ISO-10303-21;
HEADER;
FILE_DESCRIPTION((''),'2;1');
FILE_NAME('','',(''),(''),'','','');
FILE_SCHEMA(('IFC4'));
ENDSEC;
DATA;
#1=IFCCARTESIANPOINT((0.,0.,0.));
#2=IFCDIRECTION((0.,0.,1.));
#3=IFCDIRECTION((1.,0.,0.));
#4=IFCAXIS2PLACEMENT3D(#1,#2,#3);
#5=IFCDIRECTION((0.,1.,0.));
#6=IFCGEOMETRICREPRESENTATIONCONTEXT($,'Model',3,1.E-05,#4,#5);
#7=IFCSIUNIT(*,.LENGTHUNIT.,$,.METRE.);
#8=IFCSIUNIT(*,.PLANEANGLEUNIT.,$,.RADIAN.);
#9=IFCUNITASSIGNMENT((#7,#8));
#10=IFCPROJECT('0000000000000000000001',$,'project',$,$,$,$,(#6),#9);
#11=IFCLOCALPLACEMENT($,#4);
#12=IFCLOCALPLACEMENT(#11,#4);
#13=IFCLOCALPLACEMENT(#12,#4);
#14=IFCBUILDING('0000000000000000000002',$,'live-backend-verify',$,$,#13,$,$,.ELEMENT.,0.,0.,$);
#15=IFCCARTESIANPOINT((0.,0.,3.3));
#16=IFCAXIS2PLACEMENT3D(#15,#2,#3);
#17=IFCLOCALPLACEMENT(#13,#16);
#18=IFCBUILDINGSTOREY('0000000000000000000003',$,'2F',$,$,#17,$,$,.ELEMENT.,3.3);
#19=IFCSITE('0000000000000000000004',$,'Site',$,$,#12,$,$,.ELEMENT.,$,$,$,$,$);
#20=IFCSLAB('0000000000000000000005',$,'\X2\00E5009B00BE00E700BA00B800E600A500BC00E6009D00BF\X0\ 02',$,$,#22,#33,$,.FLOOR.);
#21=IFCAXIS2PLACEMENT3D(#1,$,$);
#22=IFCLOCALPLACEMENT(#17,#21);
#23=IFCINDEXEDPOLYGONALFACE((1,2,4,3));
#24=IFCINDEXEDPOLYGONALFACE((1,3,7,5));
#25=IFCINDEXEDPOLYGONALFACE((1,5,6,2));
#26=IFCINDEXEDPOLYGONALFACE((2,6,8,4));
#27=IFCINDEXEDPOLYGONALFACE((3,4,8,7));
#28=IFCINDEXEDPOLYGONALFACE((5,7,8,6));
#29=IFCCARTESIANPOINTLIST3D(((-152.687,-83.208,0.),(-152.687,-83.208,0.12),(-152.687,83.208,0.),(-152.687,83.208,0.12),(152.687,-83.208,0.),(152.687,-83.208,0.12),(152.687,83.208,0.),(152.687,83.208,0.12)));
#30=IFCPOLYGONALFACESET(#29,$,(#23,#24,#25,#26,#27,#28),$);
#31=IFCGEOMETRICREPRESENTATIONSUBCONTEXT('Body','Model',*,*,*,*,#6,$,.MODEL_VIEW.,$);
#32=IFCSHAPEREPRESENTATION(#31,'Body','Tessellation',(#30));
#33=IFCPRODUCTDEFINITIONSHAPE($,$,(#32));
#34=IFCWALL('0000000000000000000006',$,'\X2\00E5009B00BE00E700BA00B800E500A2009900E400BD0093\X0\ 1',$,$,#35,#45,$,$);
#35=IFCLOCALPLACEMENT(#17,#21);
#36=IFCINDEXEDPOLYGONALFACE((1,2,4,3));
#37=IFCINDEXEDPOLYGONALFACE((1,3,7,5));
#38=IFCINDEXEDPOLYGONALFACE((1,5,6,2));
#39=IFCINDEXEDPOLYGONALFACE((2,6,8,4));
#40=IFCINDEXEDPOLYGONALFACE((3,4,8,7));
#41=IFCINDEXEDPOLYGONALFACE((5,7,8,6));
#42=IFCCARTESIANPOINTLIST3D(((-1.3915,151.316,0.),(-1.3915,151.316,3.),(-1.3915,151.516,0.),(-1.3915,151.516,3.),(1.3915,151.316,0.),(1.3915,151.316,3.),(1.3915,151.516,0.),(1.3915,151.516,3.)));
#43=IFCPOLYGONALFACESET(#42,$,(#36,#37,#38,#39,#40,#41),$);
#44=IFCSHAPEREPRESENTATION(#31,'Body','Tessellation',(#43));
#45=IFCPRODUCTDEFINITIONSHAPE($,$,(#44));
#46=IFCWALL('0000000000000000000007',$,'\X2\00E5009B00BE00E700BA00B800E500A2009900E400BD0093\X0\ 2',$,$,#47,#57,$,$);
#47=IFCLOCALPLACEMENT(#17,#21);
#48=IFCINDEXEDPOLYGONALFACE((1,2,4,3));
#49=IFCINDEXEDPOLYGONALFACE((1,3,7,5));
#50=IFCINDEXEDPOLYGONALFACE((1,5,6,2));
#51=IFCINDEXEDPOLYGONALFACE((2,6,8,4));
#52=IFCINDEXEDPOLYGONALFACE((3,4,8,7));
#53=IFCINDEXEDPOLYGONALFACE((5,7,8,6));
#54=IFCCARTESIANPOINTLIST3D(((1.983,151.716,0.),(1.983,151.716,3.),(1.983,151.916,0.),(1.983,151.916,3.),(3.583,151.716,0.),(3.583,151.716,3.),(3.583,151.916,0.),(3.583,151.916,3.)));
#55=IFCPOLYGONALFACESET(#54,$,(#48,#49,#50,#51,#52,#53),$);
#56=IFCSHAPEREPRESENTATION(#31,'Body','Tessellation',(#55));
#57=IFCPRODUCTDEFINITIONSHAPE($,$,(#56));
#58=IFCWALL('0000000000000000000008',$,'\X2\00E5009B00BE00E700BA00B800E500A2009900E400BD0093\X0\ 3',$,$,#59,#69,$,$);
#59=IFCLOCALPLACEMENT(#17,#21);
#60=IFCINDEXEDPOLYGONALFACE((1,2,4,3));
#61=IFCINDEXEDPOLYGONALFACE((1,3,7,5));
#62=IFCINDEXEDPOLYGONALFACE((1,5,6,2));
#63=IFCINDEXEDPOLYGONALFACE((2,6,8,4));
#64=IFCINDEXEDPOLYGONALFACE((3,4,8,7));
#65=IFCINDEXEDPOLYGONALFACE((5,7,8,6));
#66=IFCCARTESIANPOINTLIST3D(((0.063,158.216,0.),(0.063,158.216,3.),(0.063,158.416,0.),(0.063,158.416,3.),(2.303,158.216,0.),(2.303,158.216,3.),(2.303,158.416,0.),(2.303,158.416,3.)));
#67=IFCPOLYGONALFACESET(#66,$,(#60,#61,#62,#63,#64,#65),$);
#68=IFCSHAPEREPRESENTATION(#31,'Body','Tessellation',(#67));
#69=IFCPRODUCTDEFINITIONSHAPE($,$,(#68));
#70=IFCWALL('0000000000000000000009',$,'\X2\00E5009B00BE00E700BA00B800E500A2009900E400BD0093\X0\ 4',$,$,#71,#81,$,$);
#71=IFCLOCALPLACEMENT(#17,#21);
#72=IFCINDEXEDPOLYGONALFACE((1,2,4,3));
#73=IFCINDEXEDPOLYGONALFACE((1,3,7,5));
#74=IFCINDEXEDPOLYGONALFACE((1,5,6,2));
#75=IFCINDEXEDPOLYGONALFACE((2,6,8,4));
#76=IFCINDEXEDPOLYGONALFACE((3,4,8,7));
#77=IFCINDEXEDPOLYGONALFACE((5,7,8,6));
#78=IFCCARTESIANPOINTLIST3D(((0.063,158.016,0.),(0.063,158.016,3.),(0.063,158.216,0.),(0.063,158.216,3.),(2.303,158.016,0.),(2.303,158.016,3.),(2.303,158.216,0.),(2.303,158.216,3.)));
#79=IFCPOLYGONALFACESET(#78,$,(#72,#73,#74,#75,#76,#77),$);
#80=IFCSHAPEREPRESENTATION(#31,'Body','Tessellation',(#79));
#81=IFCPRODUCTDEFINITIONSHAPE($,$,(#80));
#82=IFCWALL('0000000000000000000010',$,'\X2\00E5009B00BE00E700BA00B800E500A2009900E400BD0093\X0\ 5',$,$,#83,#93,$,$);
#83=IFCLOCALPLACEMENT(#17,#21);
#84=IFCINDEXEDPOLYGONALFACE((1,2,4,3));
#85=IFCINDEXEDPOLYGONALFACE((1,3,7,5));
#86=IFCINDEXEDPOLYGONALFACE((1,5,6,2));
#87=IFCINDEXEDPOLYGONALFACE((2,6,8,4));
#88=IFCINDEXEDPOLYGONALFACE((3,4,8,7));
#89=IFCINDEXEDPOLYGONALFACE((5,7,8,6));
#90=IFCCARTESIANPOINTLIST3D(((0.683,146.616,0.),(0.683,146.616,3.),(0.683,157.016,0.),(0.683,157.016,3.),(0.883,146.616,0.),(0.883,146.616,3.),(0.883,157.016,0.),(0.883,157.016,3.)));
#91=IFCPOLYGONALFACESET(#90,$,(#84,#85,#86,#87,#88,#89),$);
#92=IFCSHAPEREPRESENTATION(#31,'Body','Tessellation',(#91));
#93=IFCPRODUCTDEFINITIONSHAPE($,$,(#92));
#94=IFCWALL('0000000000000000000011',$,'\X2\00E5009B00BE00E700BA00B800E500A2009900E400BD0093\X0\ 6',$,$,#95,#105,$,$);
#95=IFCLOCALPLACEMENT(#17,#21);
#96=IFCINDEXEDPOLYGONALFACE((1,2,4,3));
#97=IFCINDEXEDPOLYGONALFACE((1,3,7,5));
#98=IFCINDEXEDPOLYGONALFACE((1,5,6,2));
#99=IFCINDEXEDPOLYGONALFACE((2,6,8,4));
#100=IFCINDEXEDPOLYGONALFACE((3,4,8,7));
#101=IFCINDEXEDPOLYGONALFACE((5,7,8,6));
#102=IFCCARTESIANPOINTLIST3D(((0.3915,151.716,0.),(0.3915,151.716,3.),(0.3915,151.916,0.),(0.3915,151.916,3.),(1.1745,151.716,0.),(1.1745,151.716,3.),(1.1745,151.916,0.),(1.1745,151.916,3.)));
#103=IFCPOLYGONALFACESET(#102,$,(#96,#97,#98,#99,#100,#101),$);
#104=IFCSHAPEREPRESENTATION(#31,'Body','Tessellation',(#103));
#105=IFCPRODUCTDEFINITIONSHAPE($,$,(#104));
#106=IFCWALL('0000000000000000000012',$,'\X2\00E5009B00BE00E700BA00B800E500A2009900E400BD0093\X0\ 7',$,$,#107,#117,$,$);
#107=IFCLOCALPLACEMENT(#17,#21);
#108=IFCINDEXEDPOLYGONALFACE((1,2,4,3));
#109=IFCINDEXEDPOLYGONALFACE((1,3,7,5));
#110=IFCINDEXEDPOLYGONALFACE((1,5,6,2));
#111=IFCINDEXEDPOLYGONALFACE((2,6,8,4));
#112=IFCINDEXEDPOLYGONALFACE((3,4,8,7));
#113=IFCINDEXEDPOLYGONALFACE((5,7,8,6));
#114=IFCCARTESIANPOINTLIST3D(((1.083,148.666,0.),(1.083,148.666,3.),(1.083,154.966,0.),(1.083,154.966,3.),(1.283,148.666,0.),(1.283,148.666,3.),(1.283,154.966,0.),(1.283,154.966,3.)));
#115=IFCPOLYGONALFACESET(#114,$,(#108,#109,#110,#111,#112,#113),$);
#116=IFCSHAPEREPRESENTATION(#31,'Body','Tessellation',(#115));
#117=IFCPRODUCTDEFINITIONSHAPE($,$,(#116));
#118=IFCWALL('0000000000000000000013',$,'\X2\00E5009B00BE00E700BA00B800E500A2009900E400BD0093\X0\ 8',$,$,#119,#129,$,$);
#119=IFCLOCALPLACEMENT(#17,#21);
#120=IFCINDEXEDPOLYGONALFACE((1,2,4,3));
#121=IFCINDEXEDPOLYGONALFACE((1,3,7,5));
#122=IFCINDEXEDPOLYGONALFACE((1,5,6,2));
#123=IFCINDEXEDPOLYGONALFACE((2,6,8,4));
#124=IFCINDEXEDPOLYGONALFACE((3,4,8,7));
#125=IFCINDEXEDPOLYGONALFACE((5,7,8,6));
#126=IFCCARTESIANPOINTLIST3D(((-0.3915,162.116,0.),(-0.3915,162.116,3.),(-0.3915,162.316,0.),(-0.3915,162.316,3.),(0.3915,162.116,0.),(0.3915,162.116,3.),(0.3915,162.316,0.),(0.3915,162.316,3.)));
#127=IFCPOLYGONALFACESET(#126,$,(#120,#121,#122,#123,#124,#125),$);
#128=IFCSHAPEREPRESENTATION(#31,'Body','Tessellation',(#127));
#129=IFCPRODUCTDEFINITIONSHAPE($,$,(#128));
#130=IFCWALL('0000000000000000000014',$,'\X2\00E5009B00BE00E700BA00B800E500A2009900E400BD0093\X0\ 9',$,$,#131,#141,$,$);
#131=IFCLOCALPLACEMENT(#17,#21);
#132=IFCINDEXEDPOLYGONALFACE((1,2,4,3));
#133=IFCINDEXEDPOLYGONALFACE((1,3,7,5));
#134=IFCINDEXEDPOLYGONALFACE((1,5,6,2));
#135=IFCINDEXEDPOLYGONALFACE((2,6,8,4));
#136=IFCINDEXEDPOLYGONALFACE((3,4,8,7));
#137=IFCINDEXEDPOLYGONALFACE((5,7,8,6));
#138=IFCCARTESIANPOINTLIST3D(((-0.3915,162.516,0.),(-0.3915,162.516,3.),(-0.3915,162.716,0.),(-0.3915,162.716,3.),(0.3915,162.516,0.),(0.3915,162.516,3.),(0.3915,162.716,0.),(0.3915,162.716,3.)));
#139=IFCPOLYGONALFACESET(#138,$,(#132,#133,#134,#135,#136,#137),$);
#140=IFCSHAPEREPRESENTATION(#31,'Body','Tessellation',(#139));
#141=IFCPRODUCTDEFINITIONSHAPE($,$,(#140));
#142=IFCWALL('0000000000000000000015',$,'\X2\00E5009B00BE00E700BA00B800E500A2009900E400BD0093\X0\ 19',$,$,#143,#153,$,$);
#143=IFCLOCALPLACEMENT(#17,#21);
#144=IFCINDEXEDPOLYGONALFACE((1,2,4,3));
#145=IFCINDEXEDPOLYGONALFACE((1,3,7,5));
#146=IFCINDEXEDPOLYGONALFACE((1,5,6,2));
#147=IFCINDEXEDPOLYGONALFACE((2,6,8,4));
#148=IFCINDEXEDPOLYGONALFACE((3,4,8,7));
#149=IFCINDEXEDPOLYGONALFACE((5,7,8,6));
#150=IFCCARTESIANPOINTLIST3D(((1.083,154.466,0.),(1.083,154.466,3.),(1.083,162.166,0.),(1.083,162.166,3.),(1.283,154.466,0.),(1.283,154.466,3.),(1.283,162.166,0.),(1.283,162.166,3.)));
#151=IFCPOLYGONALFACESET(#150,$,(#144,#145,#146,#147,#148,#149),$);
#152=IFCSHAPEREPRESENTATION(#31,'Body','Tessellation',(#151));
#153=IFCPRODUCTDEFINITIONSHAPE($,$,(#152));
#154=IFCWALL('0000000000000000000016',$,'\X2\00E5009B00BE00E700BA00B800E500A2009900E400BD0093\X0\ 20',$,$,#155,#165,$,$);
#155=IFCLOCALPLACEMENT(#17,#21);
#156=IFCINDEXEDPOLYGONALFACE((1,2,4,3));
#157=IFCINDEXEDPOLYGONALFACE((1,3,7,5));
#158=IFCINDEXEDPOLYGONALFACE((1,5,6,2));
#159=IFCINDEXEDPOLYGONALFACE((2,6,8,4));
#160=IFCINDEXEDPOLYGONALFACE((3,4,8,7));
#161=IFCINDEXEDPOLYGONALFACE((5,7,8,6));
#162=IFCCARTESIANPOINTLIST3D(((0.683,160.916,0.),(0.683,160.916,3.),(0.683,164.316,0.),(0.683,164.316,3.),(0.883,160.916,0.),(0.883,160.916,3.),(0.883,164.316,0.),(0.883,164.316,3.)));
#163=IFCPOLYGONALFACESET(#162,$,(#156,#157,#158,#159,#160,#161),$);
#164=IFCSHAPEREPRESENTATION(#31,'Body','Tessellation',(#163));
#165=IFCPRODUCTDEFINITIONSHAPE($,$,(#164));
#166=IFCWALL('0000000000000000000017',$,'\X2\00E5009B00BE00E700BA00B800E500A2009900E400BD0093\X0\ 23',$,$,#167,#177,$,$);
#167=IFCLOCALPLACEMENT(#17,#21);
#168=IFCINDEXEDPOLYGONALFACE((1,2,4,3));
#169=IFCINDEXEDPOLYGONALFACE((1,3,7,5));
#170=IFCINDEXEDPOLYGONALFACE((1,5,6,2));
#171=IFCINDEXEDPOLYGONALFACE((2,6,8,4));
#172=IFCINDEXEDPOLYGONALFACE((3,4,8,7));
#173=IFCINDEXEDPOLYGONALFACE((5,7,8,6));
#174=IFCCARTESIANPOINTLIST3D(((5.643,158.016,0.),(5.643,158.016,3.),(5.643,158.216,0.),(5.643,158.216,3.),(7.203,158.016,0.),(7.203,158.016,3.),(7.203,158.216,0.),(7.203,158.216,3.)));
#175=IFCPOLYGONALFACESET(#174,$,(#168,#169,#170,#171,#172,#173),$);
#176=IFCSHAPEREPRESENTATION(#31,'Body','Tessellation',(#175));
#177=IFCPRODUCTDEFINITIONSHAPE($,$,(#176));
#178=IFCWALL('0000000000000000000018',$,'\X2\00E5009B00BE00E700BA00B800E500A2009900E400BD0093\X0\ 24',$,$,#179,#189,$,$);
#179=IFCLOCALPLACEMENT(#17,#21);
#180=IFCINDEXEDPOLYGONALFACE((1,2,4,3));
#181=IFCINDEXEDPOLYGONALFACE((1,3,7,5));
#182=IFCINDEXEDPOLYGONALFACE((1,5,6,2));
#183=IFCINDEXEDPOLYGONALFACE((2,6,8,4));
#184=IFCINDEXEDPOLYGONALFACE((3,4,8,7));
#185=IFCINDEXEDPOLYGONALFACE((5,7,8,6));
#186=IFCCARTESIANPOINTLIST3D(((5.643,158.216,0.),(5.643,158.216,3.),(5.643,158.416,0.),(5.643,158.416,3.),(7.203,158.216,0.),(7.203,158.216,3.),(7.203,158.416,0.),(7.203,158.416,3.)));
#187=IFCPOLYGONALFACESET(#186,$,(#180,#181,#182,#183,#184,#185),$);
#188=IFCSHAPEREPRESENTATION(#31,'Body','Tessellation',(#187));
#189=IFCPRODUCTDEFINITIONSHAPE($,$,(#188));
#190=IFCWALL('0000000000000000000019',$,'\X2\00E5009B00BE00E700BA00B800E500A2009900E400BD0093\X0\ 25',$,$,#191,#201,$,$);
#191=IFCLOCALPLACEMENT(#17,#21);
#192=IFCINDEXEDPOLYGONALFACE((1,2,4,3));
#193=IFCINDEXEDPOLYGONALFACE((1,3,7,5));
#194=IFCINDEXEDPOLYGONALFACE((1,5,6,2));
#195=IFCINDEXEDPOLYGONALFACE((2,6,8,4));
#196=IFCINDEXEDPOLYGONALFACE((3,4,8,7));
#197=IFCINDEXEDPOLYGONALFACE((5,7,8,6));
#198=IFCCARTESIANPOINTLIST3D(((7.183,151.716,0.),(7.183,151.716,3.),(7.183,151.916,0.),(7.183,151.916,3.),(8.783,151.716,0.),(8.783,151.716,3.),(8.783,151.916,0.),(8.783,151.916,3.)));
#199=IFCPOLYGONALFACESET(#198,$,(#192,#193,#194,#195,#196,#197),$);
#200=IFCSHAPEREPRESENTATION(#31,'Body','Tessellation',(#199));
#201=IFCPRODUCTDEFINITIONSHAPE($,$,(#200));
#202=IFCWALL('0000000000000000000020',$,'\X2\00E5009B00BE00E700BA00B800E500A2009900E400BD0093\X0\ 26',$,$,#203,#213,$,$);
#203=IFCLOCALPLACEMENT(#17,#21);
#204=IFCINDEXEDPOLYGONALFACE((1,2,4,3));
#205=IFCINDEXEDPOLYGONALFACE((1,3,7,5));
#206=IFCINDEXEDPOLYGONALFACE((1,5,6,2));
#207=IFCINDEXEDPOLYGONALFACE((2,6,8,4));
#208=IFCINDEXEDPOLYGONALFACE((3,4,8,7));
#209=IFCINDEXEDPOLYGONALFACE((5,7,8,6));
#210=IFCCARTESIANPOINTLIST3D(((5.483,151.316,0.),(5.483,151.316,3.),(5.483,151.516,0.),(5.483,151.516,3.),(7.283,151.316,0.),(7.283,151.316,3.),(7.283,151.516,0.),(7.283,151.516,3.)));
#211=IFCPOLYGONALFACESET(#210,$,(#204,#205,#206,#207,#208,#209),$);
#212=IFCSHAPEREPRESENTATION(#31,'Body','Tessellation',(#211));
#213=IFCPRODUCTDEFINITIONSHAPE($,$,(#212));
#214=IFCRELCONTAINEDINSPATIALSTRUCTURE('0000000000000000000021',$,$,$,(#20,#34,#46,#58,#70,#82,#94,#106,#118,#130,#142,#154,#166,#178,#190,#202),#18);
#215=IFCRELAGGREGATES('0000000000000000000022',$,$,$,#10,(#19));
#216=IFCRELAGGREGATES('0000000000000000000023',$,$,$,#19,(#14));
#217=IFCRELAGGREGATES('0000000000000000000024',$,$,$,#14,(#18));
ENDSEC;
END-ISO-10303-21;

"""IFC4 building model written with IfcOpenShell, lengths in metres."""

from ifc_helpers import new_model, si_unit, direction, frame, frame_2d, origin_with_axes, place, context, subcontext, project, spatial, rectangle, extrude, element, save


model = new_model("IFC4")

# Units and contexts
model_context = context("Model", 3, precision=1e-05, world=origin_with_axes(), true_north=direction((0.0, 1.0, 0.0)))
body_context = subcontext(model_context, "Body", "Model", "MODEL_VIEW")
ifc_project = project(units=[si_unit("LENGTHUNIT", "METRE"), si_unit("PLANEANGLEUNIT", "RADIAN")], contexts=[model_context])

# Site, building, storey
placement = place(None, origin_with_axes())
site_placement = place(placement, origin_with_axes())
site = spatial("IfcSite", under=ifc_project, at=site_placement, Name="Site", CompositionType="ELEMENT")
building_placement = place(site_placement, origin_with_axes())
building = spatial("IfcBuilding", under=site, at=building_placement, Name="live-backend-verify", CompositionType="ELEMENT", ElevationOfRefHeight=0.0, ElevationOfTerrain=0.0)
storey_placement = place(building_placement, frame((0.0, 0.0, 3.3), z_axis=(0.0, 0.0, 1.0), x_axis=(1.0, 0.0, 0.0)))
storey = spatial("IfcBuildingStorey", under=building, at=storey_placement, Name="2F", CompositionType="ELEMENT", Elevation=3.3)

# Slab
slab_placement = place(storey_placement, origin_with_axes())
element("IfcSlab", 1, at=slab_placement, inside=storey, Name="å\u009b¾çº¸æ¥¼æ\u009d¿ 02", PredefinedType="FLOOR", context=body_context, shape_type="SweptSolid", body=[
    extrude(rectangle(XDim=305.374, YDim=166.416, at=frame_2d((0.0, 0.0), x_axis=(1.0, 0.0, 0.0))), frame((0.0, 0.0, 0.0), z_axis=(0.0, 0.0, 1.0)), (0.0, 0.0, 1.0), 0.12),
])

# Walls
wall_1_placement = place(storey_placement, frame((0.0, 151.416, 0.0), z_axis=(0.0, 0.0, 1.0), x_axis=(1.0, 0.0, 0.0)))
element("IfcWall", 2, at=wall_1_placement, inside=storey, Name="å\u009b¾çº¸å¢\u0099ä½\u0093 1", context=body_context, shape_type="SweptSolid", body=[
    extrude(rectangle(XDim=2.783, YDim=0.2, at=frame_2d((0.0, 0.0), x_axis=(1.0, 0.0, 0.0))), frame((0.0, 0.0, 0.0), z_axis=(0.0, 0.0, 1.0)), (0.0, 0.0, 1.0), 3.0),
])
wall_2_placement = place(storey_placement, frame((2.783, 151.816, 0.0), z_axis=(0.0, 0.0, 1.0), x_axis=(-1.0, 0.0, 0.0)))
element("IfcWall", 3, at=wall_2_placement, inside=storey, Name="å\u009b¾çº¸å¢\u0099ä½\u0093 2", context=body_context, shape_type="SweptSolid", body=[
    extrude(rectangle(XDim=1.6, YDim=0.2, at=frame_2d((0.0, 0.0), x_axis=(1.0, 0.0, 0.0))), frame((0.0, 0.0, 0.0), z_axis=(0.0, 0.0, 1.0)), (0.0, 0.0, 1.0), 3.0),
])
for number, where, z_axis, x_axis, name in (
    (4, (1.183, 158.316, 0.0), (0.0, 0.0, 1.0), (1.0, 0.0, 0.0), "å\u009b¾çº¸å¢\u0099ä½\u0093 3"),
    (5, (1.183, 158.116, 0.0), (0.0, 0.0, 1.0), (1.0, 0.0, 0.0), "å\u009b¾çº¸å¢\u0099ä½\u0093 4"),
):
    element("IfcWall", number, at=place(storey_placement, frame(where, z_axis=z_axis, x_axis=x_axis)), inside=storey, Name=name, context=body_context, shape_type="SweptSolid", body=[
        extrude(rectangle(XDim=2.24, YDim=0.2, at=frame_2d((0.0, 0.0), x_axis=(1.0, 0.0, 0.0))), frame((0.0, 0.0, 0.0), z_axis=(0.0, 0.0, 1.0)), (0.0, 0.0, 1.0), 3.0),
    ])
wall_3_placement = place(storey_placement, frame((0.783, 151.816, 0.0), z_axis=(0.0, 0.0, 1.0), x_axis=(0.0, 1.0, 0.0)))
element("IfcWall", 6, at=wall_3_placement, inside=storey, Name="å\u009b¾çº¸å¢\u0099ä½\u0093 5", context=body_context, shape_type="SweptSolid", body=[
    extrude(rectangle(XDim=10.4, YDim=0.2, at=frame_2d((0.0, 0.0), x_axis=(1.0, 0.0, 0.0))), frame((0.0, 0.0, 0.0), z_axis=(0.0, 0.0, 1.0)), (0.0, 0.0, 1.0), 3.0),
])
wall_4_placement = place(storey_placement, frame((0.783, 151.816, 0.0), z_axis=(0.0, 0.0, 1.0), x_axis=(-1.0, 0.0, 0.0)))
element("IfcWall", 7, at=wall_4_placement, inside=storey, Name="å\u009b¾çº¸å¢\u0099ä½\u0093 6", context=body_context, shape_type="SweptSolid", body=[
    extrude(rectangle(XDim=0.783, YDim=0.2, at=frame_2d((0.0, 0.0), x_axis=(1.0, 0.0, 0.0))), frame((0.0, 0.0, 0.0), z_axis=(0.0, 0.0, 1.0)), (0.0, 0.0, 1.0), 3.0),
])
wall_5_placement = place(storey_placement, frame((1.183, 151.816, 0.0), z_axis=(0.0, 0.0, 1.0), x_axis=(0.0, 1.0, 0.0)))
element("IfcWall", 8, at=wall_5_placement, inside=storey, Name="å\u009b¾çº¸å¢\u0099ä½\u0093 7", context=body_context, shape_type="SweptSolid", body=[
    extrude(rectangle(XDim=6.3, YDim=0.2, at=frame_2d((0.0, 0.0), x_axis=(1.0, 0.0, 0.0))), frame((0.0, 0.0, 0.0), z_axis=(0.0, 0.0, 1.0)), (0.0, 0.0, 1.0), 3.0),
])
for number, where, z_axis, x_axis, name in (
    (9, (0.0, 162.216, 0.0), (0.0, 0.0, 1.0), (1.0, 0.0, 0.0), "å\u009b¾çº¸å¢\u0099ä½\u0093 8"),
    (10, (0.0, 162.616, 0.0), (0.0, 0.0, 1.0), (1.0, 0.0, 0.0), "å\u009b¾çº¸å¢\u0099ä½\u0093 9"),
):
    element("IfcWall", number, at=place(storey_placement, frame(where, z_axis=z_axis, x_axis=x_axis)), inside=storey, Name=name, context=body_context, shape_type="SweptSolid", body=[
        extrude(rectangle(XDim=0.783, YDim=0.2, at=frame_2d((0.0, 0.0), x_axis=(1.0, 0.0, 0.0))), frame((0.0, 0.0, 0.0), z_axis=(0.0, 0.0, 1.0)), (0.0, 0.0, 1.0), 3.0),
    ])
wall_6_placement = place(storey_placement, frame((1.183, 158.316, 0.0), z_axis=(0.0, 0.0, 1.0), x_axis=(0.0, 1.0, 0.0)))
element("IfcWall", 11, at=wall_6_placement, inside=storey, Name="å\u009b¾çº¸å¢\u0099ä½\u0093 19", context=body_context, shape_type="SweptSolid", body=[
    extrude(rectangle(XDim=7.7, YDim=0.2, at=frame_2d((0.0, 0.0), x_axis=(1.0, 0.0, 0.0))), frame((0.0, 0.0, 0.0), z_axis=(0.0, 0.0, 1.0)), (0.0, 0.0, 1.0), 3.0),
])
wall_7_placement = place(storey_placement, frame((0.783, 162.616, 0.0), z_axis=(0.0, 0.0, 1.0), x_axis=(0.0, 1.0, 0.0)))
element("IfcWall", 12, at=wall_7_placement, inside=storey, Name="å\u009b¾çº¸å¢\u0099ä½\u0093 20", context=body_context, shape_type="SweptSolid", body=[
    extrude(rectangle(XDim=3.4, YDim=0.2, at=frame_2d((0.0, 0.0), x_axis=(1.0, 0.0, 0.0))), frame((0.0, 0.0, 0.0), z_axis=(0.0, 0.0, 1.0)), (0.0, 0.0, 1.0), 3.0),
])
for number, where, z_axis, x_axis, name in (
    (13, (6.423, 158.116, 0.0), (0.0, 0.0, 1.0), (1.0, 0.0, 0.0), "å\u009b¾çº¸å¢\u0099ä½\u0093 23"),
    (14, (6.423, 158.316, 0.0), (0.0, 0.0, 1.0), (1.0, 0.0, 0.0), "å\u009b¾çº¸å¢\u0099ä½\u0093 24"),
):
    element("IfcWall", number, at=place(storey_placement, frame(where, z_axis=z_axis, x_axis=x_axis)), inside=storey, Name=name, context=body_context, shape_type="SweptSolid", body=[
        extrude(rectangle(XDim=1.56, YDim=0.2, at=frame_2d((0.0, 0.0), x_axis=(1.0, 0.0, 0.0))), frame((0.0, 0.0, 0.0), z_axis=(0.0, 0.0, 1.0)), (0.0, 0.0, 1.0), 3.0),
    ])
wall_8_placement = place(storey_placement, frame((7.983, 151.816, 0.0), z_axis=(0.0, 0.0, 1.0), x_axis=(-1.0, 0.0, 0.0)))
element("IfcWall", 15, at=wall_8_placement, inside=storey, Name="å\u009b¾çº¸å¢\u0099ä½\u0093 25", context=body_context, shape_type="SweptSolid", body=[
    extrude(rectangle(XDim=1.6, YDim=0.2, at=frame_2d((0.0, 0.0), x_axis=(1.0, 0.0, 0.0))), frame((0.0, 0.0, 0.0), z_axis=(0.0, 0.0, 1.0)), (0.0, 0.0, 1.0), 3.0),
])
wall_9_placement = place(storey_placement, frame((6.383, 151.416, 0.0), z_axis=(0.0, 0.0, 1.0), x_axis=(1.0, 0.0, 0.0)))
element("IfcWall", 16, at=wall_9_placement, inside=storey, Name="å\u009b¾çº¸å¢\u0099ä½\u0093 26", context=body_context, shape_type="SweptSolid", body=[
    extrude(rectangle(XDim=1.8, YDim=0.2, at=frame_2d((0.0, 0.0), x_axis=(1.0, 0.0, 0.0))), frame((0.0, 0.0, 0.0), z_axis=(0.0, 0.0, 1.0)), (0.0, 0.0, 1.0), 3.0),
])

save(model, "model.ifc")
